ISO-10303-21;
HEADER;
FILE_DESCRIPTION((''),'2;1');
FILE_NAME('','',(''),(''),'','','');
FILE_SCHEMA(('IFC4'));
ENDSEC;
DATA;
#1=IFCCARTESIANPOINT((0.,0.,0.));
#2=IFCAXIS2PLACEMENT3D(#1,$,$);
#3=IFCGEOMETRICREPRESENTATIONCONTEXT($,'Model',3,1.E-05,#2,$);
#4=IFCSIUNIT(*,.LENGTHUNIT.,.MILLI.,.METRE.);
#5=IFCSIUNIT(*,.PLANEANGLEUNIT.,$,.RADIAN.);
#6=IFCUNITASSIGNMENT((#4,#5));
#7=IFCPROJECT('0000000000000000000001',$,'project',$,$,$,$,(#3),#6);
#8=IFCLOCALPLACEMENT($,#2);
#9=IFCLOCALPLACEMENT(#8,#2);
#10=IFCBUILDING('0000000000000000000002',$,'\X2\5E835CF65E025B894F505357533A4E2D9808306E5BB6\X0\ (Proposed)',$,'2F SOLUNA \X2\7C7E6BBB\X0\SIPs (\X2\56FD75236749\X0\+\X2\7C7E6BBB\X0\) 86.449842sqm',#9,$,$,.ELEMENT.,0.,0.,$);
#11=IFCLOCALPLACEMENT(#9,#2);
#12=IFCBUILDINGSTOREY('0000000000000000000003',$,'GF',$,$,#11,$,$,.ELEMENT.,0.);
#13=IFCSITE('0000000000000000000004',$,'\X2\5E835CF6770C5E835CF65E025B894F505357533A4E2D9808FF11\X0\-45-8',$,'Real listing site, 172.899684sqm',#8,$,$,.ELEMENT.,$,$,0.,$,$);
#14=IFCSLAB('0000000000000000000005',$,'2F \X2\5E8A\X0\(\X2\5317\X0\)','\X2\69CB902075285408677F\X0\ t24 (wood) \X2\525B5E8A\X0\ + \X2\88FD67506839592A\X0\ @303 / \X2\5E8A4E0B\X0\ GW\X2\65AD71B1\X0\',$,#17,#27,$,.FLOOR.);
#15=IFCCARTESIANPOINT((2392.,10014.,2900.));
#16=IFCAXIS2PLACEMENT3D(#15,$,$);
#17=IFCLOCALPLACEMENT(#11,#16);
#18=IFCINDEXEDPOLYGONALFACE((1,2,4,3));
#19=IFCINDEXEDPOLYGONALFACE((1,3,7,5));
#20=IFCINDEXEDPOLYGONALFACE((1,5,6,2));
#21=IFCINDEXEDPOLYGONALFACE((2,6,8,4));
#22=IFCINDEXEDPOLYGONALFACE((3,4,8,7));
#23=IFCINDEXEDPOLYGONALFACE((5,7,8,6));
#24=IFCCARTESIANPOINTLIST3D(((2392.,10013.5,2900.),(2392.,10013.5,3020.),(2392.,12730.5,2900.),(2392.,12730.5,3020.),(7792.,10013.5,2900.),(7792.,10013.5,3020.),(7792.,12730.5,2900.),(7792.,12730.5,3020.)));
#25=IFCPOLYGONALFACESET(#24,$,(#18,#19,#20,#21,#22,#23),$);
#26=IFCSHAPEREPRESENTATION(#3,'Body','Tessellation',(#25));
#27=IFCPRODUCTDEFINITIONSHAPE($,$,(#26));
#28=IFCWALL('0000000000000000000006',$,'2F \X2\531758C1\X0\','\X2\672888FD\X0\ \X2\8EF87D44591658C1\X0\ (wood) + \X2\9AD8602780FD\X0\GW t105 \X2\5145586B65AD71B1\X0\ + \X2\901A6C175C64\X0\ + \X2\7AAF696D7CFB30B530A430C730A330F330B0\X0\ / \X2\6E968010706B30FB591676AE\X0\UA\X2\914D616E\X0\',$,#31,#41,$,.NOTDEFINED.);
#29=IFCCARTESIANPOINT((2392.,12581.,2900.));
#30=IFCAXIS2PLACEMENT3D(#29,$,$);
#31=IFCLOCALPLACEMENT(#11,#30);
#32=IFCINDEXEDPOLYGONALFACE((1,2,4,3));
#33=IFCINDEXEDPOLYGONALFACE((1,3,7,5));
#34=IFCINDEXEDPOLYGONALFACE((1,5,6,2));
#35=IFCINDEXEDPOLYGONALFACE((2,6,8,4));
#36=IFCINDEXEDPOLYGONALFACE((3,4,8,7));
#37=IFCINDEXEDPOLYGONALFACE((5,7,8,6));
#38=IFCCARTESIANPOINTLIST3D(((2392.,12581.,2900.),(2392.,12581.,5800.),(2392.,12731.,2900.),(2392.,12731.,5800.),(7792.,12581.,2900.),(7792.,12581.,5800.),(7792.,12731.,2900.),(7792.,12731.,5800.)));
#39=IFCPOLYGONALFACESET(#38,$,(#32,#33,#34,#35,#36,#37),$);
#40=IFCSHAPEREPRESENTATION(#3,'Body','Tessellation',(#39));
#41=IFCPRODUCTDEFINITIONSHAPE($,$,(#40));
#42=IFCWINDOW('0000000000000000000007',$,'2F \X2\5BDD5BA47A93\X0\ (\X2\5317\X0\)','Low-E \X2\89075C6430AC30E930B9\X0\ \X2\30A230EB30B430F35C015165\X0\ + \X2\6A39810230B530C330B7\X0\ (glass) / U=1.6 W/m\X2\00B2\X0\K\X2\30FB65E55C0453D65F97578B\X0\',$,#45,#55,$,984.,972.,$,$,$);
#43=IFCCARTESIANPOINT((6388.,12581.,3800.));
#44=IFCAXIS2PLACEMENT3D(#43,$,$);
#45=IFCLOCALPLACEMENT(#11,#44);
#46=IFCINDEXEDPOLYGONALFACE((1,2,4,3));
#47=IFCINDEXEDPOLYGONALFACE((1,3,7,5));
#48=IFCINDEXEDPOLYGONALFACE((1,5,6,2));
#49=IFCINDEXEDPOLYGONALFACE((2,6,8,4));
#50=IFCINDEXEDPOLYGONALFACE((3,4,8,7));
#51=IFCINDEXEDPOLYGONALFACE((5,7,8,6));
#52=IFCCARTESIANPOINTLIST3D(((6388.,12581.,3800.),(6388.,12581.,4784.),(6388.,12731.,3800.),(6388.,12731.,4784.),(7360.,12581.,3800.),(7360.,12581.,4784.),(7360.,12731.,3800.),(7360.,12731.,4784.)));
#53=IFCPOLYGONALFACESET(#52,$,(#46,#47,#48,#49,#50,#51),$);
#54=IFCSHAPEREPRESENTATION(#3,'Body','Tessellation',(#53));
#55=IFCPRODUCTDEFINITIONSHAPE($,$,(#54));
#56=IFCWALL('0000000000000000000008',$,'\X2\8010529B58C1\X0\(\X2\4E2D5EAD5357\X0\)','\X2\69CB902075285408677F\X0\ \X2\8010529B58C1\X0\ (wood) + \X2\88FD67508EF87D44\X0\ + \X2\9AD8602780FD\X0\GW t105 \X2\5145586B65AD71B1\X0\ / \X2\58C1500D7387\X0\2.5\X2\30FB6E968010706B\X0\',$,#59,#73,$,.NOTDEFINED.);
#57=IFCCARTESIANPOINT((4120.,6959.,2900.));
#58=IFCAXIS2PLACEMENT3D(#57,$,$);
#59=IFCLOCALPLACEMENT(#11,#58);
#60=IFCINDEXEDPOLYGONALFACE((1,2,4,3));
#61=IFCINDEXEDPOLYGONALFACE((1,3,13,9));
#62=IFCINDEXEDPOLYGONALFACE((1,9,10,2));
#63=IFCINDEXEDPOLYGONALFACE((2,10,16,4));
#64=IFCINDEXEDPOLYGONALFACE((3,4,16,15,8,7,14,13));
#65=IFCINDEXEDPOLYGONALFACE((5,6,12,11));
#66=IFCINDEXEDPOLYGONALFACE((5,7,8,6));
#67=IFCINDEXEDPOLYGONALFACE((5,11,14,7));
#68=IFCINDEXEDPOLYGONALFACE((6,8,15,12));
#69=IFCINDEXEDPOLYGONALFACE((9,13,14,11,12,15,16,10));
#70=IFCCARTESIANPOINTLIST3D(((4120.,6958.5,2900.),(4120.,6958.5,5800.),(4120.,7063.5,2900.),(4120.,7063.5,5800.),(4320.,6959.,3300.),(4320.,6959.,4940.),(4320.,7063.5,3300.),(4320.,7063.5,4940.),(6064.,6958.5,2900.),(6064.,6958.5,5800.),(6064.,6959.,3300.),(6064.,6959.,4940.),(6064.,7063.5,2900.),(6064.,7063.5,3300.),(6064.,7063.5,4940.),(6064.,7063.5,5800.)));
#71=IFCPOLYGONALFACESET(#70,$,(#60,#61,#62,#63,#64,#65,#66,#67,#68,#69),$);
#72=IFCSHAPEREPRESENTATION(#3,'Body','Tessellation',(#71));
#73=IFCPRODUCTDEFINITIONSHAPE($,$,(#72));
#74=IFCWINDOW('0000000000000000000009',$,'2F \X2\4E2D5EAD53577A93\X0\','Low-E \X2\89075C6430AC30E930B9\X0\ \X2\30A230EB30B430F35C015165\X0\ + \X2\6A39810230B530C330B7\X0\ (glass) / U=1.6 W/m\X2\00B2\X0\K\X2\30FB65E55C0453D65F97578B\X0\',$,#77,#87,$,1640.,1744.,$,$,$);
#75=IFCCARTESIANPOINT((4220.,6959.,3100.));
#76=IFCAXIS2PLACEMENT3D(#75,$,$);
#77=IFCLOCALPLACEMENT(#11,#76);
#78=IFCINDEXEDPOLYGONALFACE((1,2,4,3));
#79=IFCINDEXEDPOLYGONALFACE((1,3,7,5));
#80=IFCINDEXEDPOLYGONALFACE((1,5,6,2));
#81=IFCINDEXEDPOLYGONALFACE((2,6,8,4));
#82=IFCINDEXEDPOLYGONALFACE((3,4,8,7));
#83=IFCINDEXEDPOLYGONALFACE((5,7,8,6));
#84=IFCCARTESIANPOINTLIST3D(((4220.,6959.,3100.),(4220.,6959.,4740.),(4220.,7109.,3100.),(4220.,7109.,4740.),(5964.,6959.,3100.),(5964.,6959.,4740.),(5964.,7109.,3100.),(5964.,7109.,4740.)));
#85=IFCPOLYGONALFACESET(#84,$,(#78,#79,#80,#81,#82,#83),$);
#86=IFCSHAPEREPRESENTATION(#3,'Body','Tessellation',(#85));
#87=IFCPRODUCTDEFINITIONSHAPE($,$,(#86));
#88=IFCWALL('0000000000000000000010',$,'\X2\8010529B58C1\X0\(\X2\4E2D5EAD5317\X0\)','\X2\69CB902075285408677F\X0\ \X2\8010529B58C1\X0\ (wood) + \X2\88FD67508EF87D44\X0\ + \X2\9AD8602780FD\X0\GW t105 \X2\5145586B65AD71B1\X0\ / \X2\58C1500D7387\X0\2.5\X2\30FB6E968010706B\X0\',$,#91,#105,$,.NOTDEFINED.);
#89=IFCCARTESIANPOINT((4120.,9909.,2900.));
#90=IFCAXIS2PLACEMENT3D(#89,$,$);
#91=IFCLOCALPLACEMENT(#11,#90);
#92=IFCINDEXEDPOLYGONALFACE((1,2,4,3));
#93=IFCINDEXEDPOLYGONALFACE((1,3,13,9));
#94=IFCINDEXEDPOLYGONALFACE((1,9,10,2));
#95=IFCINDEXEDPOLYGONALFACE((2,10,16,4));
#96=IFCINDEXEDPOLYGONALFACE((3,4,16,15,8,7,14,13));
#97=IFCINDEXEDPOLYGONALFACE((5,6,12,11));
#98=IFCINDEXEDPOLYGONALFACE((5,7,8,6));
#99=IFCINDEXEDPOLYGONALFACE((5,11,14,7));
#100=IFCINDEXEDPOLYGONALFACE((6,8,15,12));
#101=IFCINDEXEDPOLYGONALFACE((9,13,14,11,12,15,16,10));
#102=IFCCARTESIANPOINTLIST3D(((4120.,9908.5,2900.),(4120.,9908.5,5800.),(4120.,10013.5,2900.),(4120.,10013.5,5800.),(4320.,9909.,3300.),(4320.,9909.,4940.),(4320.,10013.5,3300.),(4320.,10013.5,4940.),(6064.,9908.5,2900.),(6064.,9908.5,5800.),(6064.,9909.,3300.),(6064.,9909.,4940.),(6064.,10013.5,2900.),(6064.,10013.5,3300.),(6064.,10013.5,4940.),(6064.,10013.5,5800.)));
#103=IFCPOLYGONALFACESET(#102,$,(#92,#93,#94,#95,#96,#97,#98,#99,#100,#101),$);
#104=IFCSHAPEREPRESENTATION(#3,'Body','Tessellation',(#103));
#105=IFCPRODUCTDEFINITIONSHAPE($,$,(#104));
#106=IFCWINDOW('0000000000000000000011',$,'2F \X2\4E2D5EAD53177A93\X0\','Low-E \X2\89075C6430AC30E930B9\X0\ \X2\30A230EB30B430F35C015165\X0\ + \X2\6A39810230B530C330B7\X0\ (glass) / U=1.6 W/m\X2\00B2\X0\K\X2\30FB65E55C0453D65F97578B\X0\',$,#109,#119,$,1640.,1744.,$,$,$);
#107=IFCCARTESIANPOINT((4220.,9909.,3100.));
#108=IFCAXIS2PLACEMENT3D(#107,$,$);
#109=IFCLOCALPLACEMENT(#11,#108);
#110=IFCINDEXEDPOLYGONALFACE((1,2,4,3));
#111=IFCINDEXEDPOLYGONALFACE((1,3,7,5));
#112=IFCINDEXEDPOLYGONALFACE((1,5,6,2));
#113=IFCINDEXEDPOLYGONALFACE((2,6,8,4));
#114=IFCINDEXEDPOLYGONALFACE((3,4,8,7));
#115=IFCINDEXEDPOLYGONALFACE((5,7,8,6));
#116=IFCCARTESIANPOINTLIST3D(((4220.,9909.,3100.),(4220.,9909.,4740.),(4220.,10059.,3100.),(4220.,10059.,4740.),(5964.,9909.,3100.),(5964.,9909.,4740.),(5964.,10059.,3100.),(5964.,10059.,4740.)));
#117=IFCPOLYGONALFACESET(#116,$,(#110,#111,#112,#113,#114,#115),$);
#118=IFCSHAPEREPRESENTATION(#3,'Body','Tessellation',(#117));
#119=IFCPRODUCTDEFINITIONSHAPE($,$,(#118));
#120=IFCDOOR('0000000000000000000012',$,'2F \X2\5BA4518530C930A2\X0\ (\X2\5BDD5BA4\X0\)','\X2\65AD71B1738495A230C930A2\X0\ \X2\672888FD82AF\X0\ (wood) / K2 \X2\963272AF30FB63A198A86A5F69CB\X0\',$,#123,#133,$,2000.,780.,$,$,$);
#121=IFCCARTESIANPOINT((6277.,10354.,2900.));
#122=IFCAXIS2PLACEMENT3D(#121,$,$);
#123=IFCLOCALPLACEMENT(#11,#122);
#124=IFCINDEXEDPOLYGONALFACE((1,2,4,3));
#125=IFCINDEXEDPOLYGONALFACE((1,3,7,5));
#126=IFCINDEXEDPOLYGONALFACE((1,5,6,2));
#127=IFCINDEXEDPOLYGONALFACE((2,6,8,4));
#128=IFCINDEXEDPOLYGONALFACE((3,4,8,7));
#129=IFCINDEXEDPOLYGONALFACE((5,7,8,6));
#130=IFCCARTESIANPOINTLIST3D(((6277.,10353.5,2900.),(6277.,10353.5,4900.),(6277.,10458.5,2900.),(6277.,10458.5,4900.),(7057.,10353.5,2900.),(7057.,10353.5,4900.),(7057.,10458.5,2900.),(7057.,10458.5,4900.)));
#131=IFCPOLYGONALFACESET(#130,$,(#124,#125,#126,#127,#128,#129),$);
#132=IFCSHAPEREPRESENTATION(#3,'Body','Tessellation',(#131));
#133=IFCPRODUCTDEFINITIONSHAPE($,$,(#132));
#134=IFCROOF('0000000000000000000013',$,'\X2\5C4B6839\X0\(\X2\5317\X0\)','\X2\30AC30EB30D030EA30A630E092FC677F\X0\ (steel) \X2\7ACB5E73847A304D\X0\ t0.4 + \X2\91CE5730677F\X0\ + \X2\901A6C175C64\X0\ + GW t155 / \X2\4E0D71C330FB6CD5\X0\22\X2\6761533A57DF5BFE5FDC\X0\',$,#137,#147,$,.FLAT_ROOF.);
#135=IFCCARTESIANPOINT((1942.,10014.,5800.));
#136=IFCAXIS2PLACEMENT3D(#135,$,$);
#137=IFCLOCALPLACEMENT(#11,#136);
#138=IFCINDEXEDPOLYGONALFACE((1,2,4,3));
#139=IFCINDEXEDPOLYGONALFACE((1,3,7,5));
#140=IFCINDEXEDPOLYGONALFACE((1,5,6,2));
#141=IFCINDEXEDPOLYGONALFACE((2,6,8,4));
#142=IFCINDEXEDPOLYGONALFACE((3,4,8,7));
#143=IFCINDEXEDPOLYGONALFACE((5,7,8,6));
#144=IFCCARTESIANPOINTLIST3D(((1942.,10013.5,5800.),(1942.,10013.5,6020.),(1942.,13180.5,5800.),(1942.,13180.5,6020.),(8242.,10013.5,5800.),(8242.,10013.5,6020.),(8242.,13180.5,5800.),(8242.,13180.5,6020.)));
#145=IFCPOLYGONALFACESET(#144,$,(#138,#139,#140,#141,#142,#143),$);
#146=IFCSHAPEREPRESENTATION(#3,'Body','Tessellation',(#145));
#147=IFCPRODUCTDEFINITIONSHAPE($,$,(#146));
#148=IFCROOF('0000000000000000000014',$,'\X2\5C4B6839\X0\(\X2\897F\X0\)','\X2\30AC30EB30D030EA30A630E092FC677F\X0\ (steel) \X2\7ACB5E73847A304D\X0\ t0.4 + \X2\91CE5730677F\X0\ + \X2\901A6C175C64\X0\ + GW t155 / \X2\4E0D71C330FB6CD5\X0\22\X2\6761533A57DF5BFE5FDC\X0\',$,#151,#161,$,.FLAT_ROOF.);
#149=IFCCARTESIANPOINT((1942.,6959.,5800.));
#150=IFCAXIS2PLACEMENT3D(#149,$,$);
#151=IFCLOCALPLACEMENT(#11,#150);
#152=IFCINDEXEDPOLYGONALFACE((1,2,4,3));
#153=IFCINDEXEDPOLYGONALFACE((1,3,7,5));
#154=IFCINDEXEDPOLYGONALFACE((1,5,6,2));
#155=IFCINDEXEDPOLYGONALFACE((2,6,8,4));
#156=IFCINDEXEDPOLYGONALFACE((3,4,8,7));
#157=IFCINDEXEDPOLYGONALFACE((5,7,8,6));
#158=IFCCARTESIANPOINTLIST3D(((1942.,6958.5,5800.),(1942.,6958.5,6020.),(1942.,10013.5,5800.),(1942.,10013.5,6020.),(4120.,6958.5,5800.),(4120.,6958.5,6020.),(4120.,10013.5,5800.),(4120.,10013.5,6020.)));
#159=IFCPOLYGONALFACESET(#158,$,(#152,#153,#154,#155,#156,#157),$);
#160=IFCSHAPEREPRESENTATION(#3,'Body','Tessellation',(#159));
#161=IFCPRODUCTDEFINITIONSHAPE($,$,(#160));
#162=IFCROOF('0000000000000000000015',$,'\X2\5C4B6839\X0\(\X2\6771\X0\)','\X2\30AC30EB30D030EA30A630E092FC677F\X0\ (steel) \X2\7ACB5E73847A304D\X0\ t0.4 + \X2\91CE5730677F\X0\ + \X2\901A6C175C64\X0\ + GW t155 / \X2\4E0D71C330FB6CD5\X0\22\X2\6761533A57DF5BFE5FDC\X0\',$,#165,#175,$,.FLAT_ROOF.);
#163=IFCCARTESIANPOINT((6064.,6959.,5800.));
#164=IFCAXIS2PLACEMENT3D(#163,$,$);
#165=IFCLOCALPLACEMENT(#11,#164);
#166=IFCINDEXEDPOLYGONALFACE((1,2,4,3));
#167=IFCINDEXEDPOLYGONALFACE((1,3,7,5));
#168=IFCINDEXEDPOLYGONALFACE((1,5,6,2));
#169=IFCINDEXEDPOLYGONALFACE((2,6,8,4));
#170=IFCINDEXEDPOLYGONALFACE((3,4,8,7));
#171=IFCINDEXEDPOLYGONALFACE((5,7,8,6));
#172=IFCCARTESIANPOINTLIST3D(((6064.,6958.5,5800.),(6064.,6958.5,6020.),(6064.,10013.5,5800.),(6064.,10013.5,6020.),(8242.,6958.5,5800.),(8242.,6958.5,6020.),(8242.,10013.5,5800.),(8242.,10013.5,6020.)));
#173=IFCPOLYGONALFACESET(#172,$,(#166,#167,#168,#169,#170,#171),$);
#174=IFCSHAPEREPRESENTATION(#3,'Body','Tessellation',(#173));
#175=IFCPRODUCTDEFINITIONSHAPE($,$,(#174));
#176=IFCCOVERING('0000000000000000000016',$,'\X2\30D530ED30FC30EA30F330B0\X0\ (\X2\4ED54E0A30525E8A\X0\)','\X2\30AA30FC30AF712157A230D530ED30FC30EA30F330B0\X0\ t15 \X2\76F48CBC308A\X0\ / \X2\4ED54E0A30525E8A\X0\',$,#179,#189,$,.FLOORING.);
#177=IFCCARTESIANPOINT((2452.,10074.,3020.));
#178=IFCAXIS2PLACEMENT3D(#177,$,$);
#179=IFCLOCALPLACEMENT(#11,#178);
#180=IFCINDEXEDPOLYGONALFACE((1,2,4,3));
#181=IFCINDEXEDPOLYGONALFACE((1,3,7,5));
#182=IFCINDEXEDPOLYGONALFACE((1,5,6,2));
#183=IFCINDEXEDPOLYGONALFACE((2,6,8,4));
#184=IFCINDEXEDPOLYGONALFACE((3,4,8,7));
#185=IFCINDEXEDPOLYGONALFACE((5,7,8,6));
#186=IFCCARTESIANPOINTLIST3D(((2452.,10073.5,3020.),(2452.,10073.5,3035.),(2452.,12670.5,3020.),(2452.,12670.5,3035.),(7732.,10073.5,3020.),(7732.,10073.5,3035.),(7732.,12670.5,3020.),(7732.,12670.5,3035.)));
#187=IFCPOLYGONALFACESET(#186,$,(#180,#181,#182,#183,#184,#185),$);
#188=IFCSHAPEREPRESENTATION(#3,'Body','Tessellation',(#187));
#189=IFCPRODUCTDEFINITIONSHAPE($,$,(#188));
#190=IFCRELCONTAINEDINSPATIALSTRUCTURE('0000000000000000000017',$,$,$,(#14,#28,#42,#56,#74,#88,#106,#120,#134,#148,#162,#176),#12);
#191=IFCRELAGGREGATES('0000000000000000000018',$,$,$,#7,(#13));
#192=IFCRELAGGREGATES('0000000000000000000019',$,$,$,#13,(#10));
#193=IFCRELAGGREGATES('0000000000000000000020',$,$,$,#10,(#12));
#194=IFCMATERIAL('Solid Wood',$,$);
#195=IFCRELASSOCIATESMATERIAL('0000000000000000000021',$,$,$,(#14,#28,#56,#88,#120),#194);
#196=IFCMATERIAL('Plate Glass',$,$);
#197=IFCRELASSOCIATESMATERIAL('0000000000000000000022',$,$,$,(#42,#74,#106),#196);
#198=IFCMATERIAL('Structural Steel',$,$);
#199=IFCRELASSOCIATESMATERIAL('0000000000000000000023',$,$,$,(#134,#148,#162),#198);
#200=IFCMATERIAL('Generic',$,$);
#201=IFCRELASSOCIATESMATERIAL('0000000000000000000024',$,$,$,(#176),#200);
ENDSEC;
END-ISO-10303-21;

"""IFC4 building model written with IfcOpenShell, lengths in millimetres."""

from ifc_helpers import new_model, si_unit, frame, frame_2d, origin, place, context, project, spatial, rectangle, extrude, material, element, fill, save


model = new_model("IFC4")

# Units and contexts
model_context = context("Model", 3, precision=1e-05, world=origin())
ifc_project = project(units=[si_unit("LENGTHUNIT", "METRE", prefix="MILLI"), si_unit("PLANEANGLEUNIT", "RADIAN")], contexts=[model_context])

# Site, building, storey
site_placement = place(None, origin())
site = spatial("IfcSite", under=ifc_project, at=site_placement, Name="広島県広島市安佐南区中須１-45-8", ObjectType="Real listing site, 172.899684sqm", CompositionType="ELEMENT", RefElevation=0.0)
building_placement = place(site_placement, origin())
building = spatial("IfcBuilding", under=site, at=building_placement, Name="広島市安佐南区中須の家 (Proposed)", ObjectType="2F SOLUNA 籾殻SIPs (国産杉+籾殻) 86.449842sqm", CompositionType="ELEMENT", ElevationOfRefHeight=0.0, ElevationOfTerrain=0.0)
storey_placement = place(building_placement, origin())
storey = spatial("IfcBuildingStorey", under=building, at=storey_placement, Name="GF", CompositionType="ELEMENT", Elevation=0.0)

# Slab
ifc_material_1 = material(Name="Solid Wood")
slab_placement = place(storey_placement, frame((2392.0, 10014.0, 2900.0)))
element("IfcSlab", 1, at=slab_placement, inside=storey, material=ifc_material_1, Name="2F 床(北)", Description="構造用合板 t24 (wood) 剛床 + 製材根太 @303 / 床下 GW断熱", PredefinedType="FLOOR", context=model_context, shape_type="SweptSolid", body=[
    extrude(rectangle(XDim=5400.0, YDim=2717.0, at=frame_2d((2700.0, 1358.0))), frame((2392.0, 10014.0, 2900.0)), (0.0, 0.0, 1.0), 120.0),
])

# Walls, openings, windows
wall_1_placement = place(storey_placement, frame((2392.0, 12581.0, 2900.0)))
wall_1 = element("IfcWall", 2, at=wall_1_placement, inside=storey, material=ifc_material_1, Name="2F 北壁", Description="木製 軸組外壁 (wood) + 高性能GW t105 充填断熱 + 通気層 + 窯業系サイディング / 準耐火・外皮UA配慮", PredefinedType="NOTDEFINED", context=model_context, shape_type="SweptSolid", body=[
    extrude(rectangle(XDim=5400.0, YDim=150.0, at=frame_2d((2700.0, 75.0))), frame((2392.0, 12581.0, 2900.0)), (0.0, 0.0, 1.0), 2900.0),
])
opening_1_placement = place(storey_placement, frame((6388.0, 12581.0, 3800.0)))
opening_1 = element("IfcOpeningElement", 3, at=opening_1_placement, cuts=wall_1, PredefinedType="NOTDEFINED", context=model_context, shape_type="SweptSolid", body=[
    extrude(rectangle(XDim=972.0, YDim=150.0, at=frame_2d((486.0, 75.0))), frame((6388.0, 12581.0, 3800.0)), (0.0, 0.0, 1.0), 984.0),
])
ifc_material_2 = material(Name="Plate Glass")
window_1_placement = place(storey_placement, frame((6388.0, 12581.0, 3800.0)))
window_1 = element("IfcWindow", 4, at=window_1_placement, inside=storey, material=ifc_material_2, Name="2F 寝室窓 (北)", Description="Low-E 複層ガラス アルゴン封入 + 樹脂サッシ (glass) / U=1.6 W/m²K・日射取得型", OverallHeight=984.0, OverallWidth=972.0, context=model_context, shape_type="SweptSolid", body=[
    extrude(rectangle(XDim=972.0, YDim=150.0, at=frame_2d((486.0, 75.0))), frame((6388.0, 12581.0, 3800.0)), (0.0, 0.0, 1.0), 984.0),
])
fill(opening_1, window_1)
wall_2_placement = place(storey_placement, frame((4120.0, 6959.0, 2900.0)))
wall_2 = element("IfcWall", 5, at=wall_2_placement, inside=storey, material=ifc_material_1, Name="耐力壁(中庭南)", Description="構造用合板 耐力壁 (wood) + 製材軸組 + 高性能GW t105 充填断熱 / 壁倍率2.5・準耐火", PredefinedType="NOTDEFINED", context=model_context, shape_type="SweptSolid", body=[
    extrude(rectangle(XDim=1944.0, YDim=105.0, at=frame_2d((972.0, 52.0))), frame((4120.0, 6959.0, 2900.0)), (0.0, 0.0, 1.0), 2900.0),
])
opening_2_placement = place(storey_placement, frame((4220.0, 6959.0, 3100.0)))
opening_2 = element("IfcOpeningElement", 6, at=opening_2_placement, cuts=wall_2, PredefinedType="NOTDEFINED", context=model_context, shape_type="SweptSolid", body=[
    extrude(rectangle(XDim=1744.0, YDim=150.0, at=frame_2d((872.0, 75.0))), frame((4220.0, 6959.0, 3100.0)), (0.0, 0.0, 1.0), 1640.0),
])
window_2_placement = place(storey_placement, frame((4220.0, 6959.0, 3100.0)))
window_2 = element("IfcWindow", 7, at=window_2_placement, inside=storey, material=ifc_material_2, Name="2F 中庭南窓", Description="Low-E 複層ガラス アルゴン封入 + 樹脂サッシ (glass) / U=1.6 W/m²K・日射取得型", OverallHeight=1640.0, OverallWidth=1744.0, context=model_context, shape_type="SweptSolid", body=[
    extrude(rectangle(XDim=1744.0, YDim=150.0, at=frame_2d((872.0, 75.0))), frame((4220.0, 6959.0, 3100.0)), (0.0, 0.0, 1.0), 1640.0),
])
fill(opening_2, window_2)
wall_3_placement = place(storey_placement, frame((4120.0, 9909.0, 2900.0)))
wall_3 = element("IfcWall", 8, at=wall_3_placement, inside=storey, material=ifc_material_1, Name="耐力壁(中庭北)", Description="構造用合板 耐力壁 (wood) + 製材軸組 + 高性能GW t105 充填断熱 / 壁倍率2.5・準耐火", PredefinedType="NOTDEFINED", context=model_context, shape_type="SweptSolid", body=[
    extrude(rectangle(XDim=1944.0, YDim=105.0, at=frame_2d((972.0, 52.0))), frame((4120.0, 9909.0, 2900.0)), (0.0, 0.0, 1.0), 2900.0),
])
opening_3_placement = place(storey_placement, frame((4220.0, 9909.0, 3100.0)))
opening_3 = element("IfcOpeningElement", 9, at=opening_3_placement, cuts=wall_3, PredefinedType="NOTDEFINED", context=model_context, shape_type="SweptSolid", body=[
    extrude(rectangle(XDim=1744.0, YDim=150.0, at=frame_2d((872.0, 75.0))), frame((4220.0, 9909.0, 3100.0)), (0.0, 0.0, 1.0), 1640.0),
])
window_3_placement = place(storey_placement, frame((4220.0, 9909.0, 3100.0)))
window_3 = element("IfcWindow", 10, at=window_3_placement, inside=storey, material=ifc_material_2, Name="2F 中庭北窓", Description="Low-E 複層ガラス アルゴン封入 + 樹脂サッシ (glass) / U=1.6 W/m²K・日射取得型", OverallHeight=1640.0, OverallWidth=1744.0, context=model_context, shape_type="SweptSolid", body=[
    extrude(rectangle(XDim=1744.0, YDim=150.0, at=frame_2d((872.0, 75.0))), frame((4220.0, 9909.0, 3100.0)), (0.0, 0.0, 1.0), 1640.0),
])
fill(opening_3, window_3)

# Door
door_placement = place(storey_placement, frame((6277.0, 10354.0, 2900.0)))
element("IfcDoor", 11, at=door_placement, inside=storey, material=ifc_material_1, Name="2F 室内ドア (寝室)", Description="断熱玄関ドア 木製芯 (wood) / K2 防犯・採風機構", OverallHeight=2000.0, OverallWidth=780.0, context=model_context, shape_type="SweptSolid", body=[
    extrude(rectangle(XDim=780.0, YDim=105.0, at=frame_2d((390.0, 52.0))), frame((6277.0, 10354.0, 2900.0)), (0.0, 0.0, 1.0), 2000.0),
])

# Roofs
ifc_material_3 = material(Name="Structural Steel")
for number, where, name in (
    (12, (1942.0, 10014.0, 5800.0), "屋根(北)"),
):
    element("IfcRoof", number, at=place(storey_placement, frame(where)), inside=storey, material=ifc_material_3, Name=name, Description="ガルバリウム鋼板 (steel) 立平葺き t0.4 + 野地板 + 通気層 + GW t155 / 不燃・法22条区域対応", PredefinedType="FLAT_ROOF", context=model_context, shape_type="SweptSolid", body=[
        extrude(rectangle(XDim=6300.0, YDim=3167.0, at=frame_2d((3150.0, 1583.0))), frame((1942.0, 10014.0, 5800.0)), (0.0, 0.0, 1.0), 220.0),
    ])
roof_1_placement = place(storey_placement, frame((1942.0, 6959.0, 5800.0)))
element("IfcRoof", 13, at=roof_1_placement, inside=storey, material=ifc_material_3, Name="屋根(西)", Description="ガルバリウム鋼板 (steel) 立平葺き t0.4 + 野地板 + 通気層 + GW t155 / 不燃・法22条区域対応", PredefinedType="FLAT_ROOF", context=model_context, shape_type="SweptSolid", body=[
    extrude(rectangle(XDim=2178.0, YDim=3055.0, at=frame_2d((1089.0, 1527.0))), frame((1942.0, 6959.0, 5800.0)), (0.0, 0.0, 1.0), 220.0),
])
roof_2_placement = place(storey_placement, frame((6064.0, 6959.0, 5800.0)))
element("IfcRoof", 14, at=roof_2_placement, inside=storey, material=ifc_material_3, Name="屋根(東)", Description="ガルバリウム鋼板 (steel) 立平葺き t0.4 + 野地板 + 通気層 + GW t155 / 不燃・法22条区域対応", PredefinedType="FLAT_ROOF", context=model_context, shape_type="SweptSolid", body=[
    extrude(rectangle(XDim=2178.0, YDim=3055.0, at=frame_2d((1089.0, 1527.0))), frame((6064.0, 6959.0, 5800.0)), (0.0, 0.0, 1.0), 220.0),
])

# Covering
ifc_material_4 = material(Name="Generic")
covering_1_placement = place(storey_placement, frame((2452.0, 10074.0, 3020.0)))
element("IfcCovering", 15, at=covering_1_placement, inside=storey, material=ifc_material_4, Name="フローリング (仕上げ床)", Description="オーク無垢フローリング t15 直貼り / 仕上げ床", PredefinedType="FLOORING", context=model_context, shape_type="SweptSolid", body=[
    extrude(rectangle(XDim=5280.0, YDim=2597.0, at=frame_2d((2640.0, 1298.0))), frame((2452.0, 10074.0, 3020.0)), (0.0, 0.0, 1.0), 15.0),
])

save(model, "model.ifc")
